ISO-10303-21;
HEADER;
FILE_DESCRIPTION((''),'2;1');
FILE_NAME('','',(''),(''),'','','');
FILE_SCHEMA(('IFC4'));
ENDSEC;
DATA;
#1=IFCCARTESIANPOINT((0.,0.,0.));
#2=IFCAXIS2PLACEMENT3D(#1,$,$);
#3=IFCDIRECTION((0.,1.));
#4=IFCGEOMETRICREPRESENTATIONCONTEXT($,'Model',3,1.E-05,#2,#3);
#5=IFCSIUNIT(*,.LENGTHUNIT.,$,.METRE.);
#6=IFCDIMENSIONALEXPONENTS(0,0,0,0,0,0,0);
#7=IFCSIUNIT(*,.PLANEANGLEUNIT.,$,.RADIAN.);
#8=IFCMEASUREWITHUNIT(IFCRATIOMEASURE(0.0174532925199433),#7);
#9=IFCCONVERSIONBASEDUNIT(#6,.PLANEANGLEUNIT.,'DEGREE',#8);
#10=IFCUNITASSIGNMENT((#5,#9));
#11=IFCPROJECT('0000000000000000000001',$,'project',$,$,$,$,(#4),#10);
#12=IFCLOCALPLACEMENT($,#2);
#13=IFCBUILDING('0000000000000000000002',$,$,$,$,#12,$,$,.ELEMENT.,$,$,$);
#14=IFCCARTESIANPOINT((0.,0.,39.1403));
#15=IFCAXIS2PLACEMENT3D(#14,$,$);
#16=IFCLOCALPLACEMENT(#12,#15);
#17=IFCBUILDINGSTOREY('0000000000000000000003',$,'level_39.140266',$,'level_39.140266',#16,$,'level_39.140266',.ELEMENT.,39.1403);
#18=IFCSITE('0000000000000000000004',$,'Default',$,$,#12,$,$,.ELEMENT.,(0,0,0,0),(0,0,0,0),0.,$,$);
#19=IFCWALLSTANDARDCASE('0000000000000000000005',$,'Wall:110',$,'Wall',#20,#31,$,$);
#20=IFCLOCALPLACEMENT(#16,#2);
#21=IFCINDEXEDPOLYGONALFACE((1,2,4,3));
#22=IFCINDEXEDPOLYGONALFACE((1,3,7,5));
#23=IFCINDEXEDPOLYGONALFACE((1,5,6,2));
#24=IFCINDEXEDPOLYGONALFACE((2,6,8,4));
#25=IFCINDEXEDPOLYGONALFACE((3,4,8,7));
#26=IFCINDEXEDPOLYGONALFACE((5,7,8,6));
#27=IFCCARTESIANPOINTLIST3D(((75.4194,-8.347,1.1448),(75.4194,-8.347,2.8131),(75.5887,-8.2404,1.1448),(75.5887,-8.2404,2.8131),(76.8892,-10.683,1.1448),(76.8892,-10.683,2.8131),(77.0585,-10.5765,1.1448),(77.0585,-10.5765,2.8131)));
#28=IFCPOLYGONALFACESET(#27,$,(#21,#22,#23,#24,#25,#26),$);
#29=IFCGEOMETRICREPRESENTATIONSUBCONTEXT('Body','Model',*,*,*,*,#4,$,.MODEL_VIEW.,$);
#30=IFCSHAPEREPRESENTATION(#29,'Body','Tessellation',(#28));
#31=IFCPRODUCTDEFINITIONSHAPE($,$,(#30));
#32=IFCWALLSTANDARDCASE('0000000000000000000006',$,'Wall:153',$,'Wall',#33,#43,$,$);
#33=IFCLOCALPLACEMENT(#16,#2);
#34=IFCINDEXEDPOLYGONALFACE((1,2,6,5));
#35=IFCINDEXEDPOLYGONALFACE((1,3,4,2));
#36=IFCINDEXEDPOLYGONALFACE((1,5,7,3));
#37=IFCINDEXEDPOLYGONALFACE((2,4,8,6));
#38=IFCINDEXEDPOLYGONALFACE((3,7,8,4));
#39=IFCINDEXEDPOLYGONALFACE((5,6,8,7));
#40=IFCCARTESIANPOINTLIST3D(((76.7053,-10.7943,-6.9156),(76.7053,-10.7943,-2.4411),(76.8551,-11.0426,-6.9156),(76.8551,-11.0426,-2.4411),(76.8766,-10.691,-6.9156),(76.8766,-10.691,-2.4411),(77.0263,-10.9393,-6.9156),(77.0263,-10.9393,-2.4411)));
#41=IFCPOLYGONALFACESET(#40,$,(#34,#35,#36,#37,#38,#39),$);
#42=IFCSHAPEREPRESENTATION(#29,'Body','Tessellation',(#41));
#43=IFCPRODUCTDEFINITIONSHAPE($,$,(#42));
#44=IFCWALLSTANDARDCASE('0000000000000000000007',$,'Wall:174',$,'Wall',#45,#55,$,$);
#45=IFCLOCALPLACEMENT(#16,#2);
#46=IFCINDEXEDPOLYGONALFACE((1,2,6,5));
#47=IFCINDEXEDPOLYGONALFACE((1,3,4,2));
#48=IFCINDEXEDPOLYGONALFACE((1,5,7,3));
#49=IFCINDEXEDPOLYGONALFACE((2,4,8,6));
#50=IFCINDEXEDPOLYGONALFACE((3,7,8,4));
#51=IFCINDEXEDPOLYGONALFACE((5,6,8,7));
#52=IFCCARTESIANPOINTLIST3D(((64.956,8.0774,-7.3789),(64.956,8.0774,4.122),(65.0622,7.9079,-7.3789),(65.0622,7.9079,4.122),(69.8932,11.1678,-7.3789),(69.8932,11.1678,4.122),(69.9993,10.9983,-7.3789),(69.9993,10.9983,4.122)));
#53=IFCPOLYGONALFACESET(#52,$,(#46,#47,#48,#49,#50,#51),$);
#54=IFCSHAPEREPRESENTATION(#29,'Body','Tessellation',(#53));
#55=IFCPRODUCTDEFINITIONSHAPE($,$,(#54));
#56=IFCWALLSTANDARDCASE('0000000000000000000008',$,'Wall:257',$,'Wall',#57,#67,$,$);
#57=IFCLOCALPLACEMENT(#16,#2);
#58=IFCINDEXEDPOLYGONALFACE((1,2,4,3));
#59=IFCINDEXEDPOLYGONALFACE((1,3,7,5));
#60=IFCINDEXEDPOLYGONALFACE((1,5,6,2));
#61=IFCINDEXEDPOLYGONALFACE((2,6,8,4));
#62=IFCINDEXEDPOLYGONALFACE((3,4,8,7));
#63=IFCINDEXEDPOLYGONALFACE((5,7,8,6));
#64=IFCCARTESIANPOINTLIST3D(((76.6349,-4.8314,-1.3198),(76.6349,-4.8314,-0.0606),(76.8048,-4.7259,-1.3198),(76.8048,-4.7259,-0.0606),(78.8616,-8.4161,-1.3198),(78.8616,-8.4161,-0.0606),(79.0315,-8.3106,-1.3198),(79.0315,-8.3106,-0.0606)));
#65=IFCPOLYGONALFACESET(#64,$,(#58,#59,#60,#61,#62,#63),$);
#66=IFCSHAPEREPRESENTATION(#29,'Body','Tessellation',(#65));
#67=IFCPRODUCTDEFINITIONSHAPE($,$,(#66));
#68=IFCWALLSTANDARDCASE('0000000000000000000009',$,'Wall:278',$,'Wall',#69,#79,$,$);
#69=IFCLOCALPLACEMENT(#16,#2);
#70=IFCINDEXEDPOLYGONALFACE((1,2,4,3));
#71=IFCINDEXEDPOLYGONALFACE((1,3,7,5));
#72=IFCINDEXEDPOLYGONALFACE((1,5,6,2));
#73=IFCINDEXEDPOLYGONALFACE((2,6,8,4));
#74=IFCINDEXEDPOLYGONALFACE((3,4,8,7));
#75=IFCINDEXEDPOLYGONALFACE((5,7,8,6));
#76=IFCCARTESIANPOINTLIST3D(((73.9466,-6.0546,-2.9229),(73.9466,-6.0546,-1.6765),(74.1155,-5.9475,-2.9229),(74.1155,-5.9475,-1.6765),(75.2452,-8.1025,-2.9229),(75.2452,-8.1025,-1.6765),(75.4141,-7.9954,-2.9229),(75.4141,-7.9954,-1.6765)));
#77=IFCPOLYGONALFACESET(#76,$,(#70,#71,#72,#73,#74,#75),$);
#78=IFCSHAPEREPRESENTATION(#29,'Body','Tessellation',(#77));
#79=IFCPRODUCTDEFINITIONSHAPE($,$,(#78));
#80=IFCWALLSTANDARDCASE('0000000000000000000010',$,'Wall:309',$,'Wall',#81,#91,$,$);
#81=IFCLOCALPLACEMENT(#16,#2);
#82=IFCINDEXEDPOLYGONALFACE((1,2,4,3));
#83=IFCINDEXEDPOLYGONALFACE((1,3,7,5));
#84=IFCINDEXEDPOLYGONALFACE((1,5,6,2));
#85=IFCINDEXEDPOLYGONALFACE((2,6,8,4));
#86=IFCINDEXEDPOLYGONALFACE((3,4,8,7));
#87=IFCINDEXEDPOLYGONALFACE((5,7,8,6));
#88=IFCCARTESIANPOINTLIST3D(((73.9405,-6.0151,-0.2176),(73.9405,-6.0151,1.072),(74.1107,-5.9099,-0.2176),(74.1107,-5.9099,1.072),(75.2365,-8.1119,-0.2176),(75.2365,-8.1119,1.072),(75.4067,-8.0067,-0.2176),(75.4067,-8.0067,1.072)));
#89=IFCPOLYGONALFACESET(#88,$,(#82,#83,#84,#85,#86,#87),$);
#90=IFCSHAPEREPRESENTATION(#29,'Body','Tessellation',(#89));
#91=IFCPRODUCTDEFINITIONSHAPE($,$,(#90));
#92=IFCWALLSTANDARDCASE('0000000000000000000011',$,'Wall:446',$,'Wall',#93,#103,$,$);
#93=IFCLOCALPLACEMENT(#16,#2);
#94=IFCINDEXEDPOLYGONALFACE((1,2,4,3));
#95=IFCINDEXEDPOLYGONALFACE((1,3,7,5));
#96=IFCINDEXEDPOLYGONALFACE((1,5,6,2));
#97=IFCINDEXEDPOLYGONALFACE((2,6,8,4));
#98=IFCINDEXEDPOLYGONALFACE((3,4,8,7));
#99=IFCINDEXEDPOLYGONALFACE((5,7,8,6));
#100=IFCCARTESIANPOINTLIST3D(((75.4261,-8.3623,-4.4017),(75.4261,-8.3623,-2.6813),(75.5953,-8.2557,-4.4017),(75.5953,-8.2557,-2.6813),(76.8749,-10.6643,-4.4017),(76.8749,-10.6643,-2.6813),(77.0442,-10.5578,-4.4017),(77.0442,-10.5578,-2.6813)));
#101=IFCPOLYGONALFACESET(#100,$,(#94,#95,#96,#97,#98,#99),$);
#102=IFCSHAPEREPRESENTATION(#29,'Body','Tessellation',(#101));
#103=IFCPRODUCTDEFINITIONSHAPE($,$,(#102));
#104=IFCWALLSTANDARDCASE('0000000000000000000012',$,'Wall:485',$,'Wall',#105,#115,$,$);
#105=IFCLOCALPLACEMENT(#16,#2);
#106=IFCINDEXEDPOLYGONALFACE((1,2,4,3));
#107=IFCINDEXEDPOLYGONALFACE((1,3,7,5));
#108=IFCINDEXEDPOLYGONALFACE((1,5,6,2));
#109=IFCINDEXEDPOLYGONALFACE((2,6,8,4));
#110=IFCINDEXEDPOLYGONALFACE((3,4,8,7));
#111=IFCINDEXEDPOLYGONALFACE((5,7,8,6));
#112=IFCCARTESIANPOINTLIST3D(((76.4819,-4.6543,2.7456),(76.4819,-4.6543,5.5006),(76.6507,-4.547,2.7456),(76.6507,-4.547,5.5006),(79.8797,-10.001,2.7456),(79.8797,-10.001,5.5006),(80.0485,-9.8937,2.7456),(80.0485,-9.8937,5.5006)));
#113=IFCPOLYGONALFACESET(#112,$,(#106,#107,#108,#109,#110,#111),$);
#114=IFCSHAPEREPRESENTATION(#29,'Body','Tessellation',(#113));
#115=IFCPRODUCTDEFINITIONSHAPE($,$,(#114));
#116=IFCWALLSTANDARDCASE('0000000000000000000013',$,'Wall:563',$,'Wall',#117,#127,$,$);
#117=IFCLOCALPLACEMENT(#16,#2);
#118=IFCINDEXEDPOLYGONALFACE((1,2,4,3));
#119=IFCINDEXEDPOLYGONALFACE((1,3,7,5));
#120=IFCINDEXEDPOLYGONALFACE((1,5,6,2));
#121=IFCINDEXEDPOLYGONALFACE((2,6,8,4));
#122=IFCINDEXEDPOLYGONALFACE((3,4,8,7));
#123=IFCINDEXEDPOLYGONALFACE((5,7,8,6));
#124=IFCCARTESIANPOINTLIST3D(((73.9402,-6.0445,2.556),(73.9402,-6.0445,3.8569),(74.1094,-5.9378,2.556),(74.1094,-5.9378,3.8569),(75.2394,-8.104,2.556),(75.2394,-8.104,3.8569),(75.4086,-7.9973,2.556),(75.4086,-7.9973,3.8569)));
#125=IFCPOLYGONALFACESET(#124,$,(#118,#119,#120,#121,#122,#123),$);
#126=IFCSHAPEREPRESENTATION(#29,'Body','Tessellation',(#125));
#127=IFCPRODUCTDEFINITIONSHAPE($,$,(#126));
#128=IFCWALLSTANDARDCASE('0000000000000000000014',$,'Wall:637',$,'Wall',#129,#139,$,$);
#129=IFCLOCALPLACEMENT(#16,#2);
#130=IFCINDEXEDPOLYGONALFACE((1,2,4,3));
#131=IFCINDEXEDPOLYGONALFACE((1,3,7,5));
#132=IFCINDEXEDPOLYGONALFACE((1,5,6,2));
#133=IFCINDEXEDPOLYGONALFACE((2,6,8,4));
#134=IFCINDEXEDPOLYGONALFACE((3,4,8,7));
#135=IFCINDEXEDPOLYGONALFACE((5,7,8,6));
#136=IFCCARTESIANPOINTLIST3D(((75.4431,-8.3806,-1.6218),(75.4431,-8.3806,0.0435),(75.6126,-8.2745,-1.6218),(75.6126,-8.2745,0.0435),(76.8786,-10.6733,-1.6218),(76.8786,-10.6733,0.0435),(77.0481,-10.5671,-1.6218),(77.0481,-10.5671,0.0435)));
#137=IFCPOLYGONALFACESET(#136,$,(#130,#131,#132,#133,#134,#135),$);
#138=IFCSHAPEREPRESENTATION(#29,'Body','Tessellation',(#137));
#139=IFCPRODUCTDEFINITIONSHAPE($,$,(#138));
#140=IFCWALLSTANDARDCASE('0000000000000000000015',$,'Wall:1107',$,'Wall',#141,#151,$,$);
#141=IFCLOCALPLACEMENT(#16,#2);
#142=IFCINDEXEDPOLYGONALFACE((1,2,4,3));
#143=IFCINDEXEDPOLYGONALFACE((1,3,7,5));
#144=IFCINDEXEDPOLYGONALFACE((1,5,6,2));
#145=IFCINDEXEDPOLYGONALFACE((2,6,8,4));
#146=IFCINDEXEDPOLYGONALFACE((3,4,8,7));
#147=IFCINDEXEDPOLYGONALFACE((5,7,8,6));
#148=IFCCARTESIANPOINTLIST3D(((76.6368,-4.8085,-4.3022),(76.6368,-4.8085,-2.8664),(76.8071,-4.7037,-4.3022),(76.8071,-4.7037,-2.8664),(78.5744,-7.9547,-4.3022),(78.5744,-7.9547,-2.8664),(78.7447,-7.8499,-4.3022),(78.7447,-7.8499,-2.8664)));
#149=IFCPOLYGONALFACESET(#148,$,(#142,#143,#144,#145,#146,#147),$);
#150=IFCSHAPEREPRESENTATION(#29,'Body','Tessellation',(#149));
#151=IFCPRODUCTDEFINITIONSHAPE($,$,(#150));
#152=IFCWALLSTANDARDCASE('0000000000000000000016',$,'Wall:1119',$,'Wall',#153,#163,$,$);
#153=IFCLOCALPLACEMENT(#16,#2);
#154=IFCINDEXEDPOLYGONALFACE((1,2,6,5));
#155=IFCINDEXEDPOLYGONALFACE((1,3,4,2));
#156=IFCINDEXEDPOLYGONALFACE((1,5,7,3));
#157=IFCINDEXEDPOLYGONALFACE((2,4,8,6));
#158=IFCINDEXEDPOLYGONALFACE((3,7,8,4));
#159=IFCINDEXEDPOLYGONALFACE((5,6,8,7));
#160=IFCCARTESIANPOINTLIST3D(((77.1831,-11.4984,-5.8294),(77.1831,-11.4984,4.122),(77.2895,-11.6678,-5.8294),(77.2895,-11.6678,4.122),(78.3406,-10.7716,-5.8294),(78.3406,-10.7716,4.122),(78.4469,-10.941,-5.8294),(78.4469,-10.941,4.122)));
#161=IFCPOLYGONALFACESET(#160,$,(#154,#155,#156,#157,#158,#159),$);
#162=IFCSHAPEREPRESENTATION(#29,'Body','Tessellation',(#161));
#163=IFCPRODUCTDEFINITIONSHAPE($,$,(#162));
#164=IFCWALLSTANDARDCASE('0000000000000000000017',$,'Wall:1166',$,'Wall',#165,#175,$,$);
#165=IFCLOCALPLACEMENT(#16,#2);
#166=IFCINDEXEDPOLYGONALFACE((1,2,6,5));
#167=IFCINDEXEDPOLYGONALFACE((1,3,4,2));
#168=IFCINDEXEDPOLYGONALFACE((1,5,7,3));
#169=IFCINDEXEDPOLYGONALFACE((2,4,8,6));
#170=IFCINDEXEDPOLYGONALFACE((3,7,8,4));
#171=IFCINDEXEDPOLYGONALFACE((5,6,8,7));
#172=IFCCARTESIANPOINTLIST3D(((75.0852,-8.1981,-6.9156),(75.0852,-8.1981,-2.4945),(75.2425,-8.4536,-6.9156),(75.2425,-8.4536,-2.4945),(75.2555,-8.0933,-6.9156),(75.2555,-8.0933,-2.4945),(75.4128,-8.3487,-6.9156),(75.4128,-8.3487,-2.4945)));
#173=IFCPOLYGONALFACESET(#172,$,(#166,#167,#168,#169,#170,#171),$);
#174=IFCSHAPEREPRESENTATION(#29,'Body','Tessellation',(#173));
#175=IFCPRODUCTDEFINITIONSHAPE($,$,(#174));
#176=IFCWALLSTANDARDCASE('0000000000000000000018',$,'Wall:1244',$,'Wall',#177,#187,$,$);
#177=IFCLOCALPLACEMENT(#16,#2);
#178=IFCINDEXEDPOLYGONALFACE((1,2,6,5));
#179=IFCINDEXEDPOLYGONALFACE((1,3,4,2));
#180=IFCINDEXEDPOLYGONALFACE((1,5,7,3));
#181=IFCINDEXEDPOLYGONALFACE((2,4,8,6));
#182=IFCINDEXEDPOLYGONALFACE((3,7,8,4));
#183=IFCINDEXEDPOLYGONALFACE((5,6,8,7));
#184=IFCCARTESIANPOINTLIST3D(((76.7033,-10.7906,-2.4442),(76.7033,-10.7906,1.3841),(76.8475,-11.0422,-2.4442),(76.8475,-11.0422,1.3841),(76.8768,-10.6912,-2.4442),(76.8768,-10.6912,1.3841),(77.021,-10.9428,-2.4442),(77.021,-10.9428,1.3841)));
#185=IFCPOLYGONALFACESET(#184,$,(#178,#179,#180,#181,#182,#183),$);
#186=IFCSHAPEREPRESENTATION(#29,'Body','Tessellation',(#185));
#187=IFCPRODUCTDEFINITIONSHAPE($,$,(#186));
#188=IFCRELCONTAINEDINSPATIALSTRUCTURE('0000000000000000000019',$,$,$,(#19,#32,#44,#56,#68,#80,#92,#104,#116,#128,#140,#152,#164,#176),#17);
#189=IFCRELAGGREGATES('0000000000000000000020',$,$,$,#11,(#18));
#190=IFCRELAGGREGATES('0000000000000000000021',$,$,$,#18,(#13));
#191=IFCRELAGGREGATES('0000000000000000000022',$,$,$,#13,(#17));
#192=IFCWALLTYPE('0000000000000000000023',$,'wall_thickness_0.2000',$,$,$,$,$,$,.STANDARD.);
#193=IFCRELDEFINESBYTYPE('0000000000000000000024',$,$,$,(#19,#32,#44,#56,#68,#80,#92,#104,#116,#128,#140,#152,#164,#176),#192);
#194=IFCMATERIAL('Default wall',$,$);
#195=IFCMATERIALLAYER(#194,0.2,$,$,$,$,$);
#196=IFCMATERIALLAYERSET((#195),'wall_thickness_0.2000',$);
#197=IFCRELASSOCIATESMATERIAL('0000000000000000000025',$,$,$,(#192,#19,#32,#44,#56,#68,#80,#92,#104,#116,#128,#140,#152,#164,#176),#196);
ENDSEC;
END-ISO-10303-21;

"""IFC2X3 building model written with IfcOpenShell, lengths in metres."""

from ifc_helpers import new_model, entity, si_unit, converted_unit, direction, frame, origin, place, context, subcontext, project, spatial, polyline, outline, extrude, material, layer, layer_set, layer_usage, type_object, element, save


model = new_model("IFC2X3")

# Units and contexts
model_context = context("Model", 3, precision=1e-05, world=origin(), true_north=direction((0.0, 1.0)))
body_context = subcontext(model_context, "Body", "Model", "MODEL_VIEW")
ifc_project = project(units=[si_unit("LENGTHUNIT", "METRE"), converted_unit("PLANEANGLEUNIT", "DEGREE", entity("IfcRatioMeasure", 0.0174532925199433), si_unit("PLANEANGLEUNIT", "RADIAN"), dimensions=[0, 0, 0, 0, 0, 0, 0])], contexts=[model_context])

# Site, building, storey
placement_1 = place(None, origin())
site = spatial("IfcSite", under=ifc_project, at=placement_1, Name="Default", CompositionType="ELEMENT", RefLatitude=(0, 0, 0, 0), RefLongitude=(0, 0, 0, 0), RefElevation=0.0)
building = spatial("IfcBuilding", under=site, at=placement_1, CompositionType="ELEMENT")
storey_placement = place(placement_1, frame((0.0, 0.0, 39.1403)))
storey = spatial("IfcBuildingStorey", under=building, at=storey_placement, Name="level_39.140266", ObjectType="level_39.140266", LongName="level_39.140266", CompositionType="ELEMENT", Elevation=39.1403)

# Walls
ifc_material = material(Name="Default wall")
ifc_layer = layer(ifc_material, 0.2)
ifc_layer_set = layer_set([ifc_layer], Name="wall_thickness_0.2000")
ifc_layer_usage = layer_usage(ifc_layer_set, "AXIS2", "POSITIVE", -0.1)
wall_type = type_object("IfcWallType", Name="wall_thickness_0.2000", PredefinedType="STANDARD", material=ifc_layer_set)
placement_2 = place(placement_1, frame((0.0, 0.0, 40.2851)))
wall_1_placement = place(placement_2, frame((75.504, -8.2937, 0.0), z_axis=(0.0, 0.0, 1.0), x_axis=(0.532531, -0.84641, 0.0)))
element("IfcWallStandardCase", 1, at=wall_1_placement, inside=storey, type_object=wall_type, material=ifc_layer_usage, Name="Wall:110", ObjectType="Wall", context=body_context, shape_type="SweptSolid", body=[
    extrude(outline(polyline([(2.76, -0.1), (2.76, 0.1), (0.0, 0.1), (0.0, -0.1), (2.76, -0.1)])), origin(), (0.0, 0.0, 1.0), 1.6683),
])
placement_3 = place(placement_1, frame((0.0, 0.0, 32.2247)))
wall_2_placement = place(placement_3, frame((76.7909, -10.7427, 0.0), z_axis=(0.0, 0.0, 1.0), x_axis=(0.516457, -0.856313, 0.0)))
element("IfcWallStandardCase", 2, at=wall_2_placement, inside=storey, type_object=wall_type, material=ifc_layer_usage, Name="Wall:153", ObjectType="Wall", context=body_context, shape_type="SweptSolid", body=[
    extrude(outline(polyline([(0.29, -0.1), (0.29, 0.1), (0.0, 0.1), (0.0, -0.1), (0.29, -0.1)])), origin(), (0.0, 0.0, 1.0), 4.4746),
])
placement_4 = place(placement_1, frame((0.0, 0.0, 31.7614)))
wall_3_placement = place(placement_4, frame((69.9462, 11.083, 0.0), z_axis=(0.0, 0.0, 1.0), x_axis=(-0.847635, -0.530581, 0.0)))
element("IfcWallStandardCase", 3, at=wall_3_placement, inside=storey, type_object=wall_type, material=ifc_layer_usage, Name="Wall:174", ObjectType="Wall", context=body_context, shape_type="SweptSolid", body=[
    extrude(outline(polyline([(5.8246, -0.1), (5.8246, 0.1), (0.0, 0.1), (0.0, -0.1), (5.8246, -0.1)])), origin(), (0.0, 0.0, 1.0), 11.5009),
])
placement_5 = place(placement_1, frame((0.0, 0.0, 37.8205)))
wall_4_placement = place(placement_5, frame((76.7198, -4.7787, 0.0), z_axis=(0.0, 0.0, 1.0), x_axis=(0.527667, -0.849452, 0.0)))
element("IfcWallStandardCase", 4, at=wall_4_placement, inside=storey, type_object=wall_type, material=ifc_layer_usage, Name="Wall:257", ObjectType="Wall", context=body_context, shape_type="SweptSolid", body=[
    extrude(outline(polyline([(4.22, -0.1), (4.22, 0.1), (0.0, 0.1), (0.0, -0.1), (4.22, -0.1)])), origin(), (0.0, 0.0, 1.0), 1.2592),
])
placement_6 = place(placement_1, frame((0.0, 0.0, 36.2174)))
wall_5_placement = place(placement_6, frame((74.031, -6.001, 0.0), z_axis=(0.0, 0.0, 1.0), x_axis=(0.535521, -0.844522, 0.0)))
element("IfcWallStandardCase", 5, at=wall_5_placement, inside=storey, type_object=wall_type, material=ifc_layer_usage, Name="Wall:278", ObjectType="Wall", context=body_context, shape_type="SweptSolid", body=[
    extrude(outline(polyline([(2.425, -0.1), (2.425, 0.1), (0.0, 0.1), (0.0, -0.1), (2.425, -0.1)])), origin(), (0.0, 0.0, 1.0), 1.2464),
])
placement_7 = place(placement_1, frame((0.0, 0.0, 38.9227)))
wall_6_placement = place(placement_7, frame((74.0256, -5.9625, 0.0), z_axis=(0.0, 0.0, 1.0), x_axis=(0.52576, -0.850633, 0.0)))
element("IfcWallStandardCase", 6, at=wall_6_placement, inside=storey, type_object=wall_type, material=ifc_layer_usage, Name="Wall:309", ObjectType="Wall", context=body_context, shape_type="SweptSolid", body=[
    extrude(outline(polyline([(2.465, -0.1), (2.465, 0.1), (0.0, 0.1), (0.0, -0.1), (2.465, -0.1)])), origin(), (0.0, 0.0, 1.0), 1.2896),
])
placement_8 = place(placement_1, frame((0.0, 0.0, 34.7386)))
wall_7_placement = place(placement_8, frame((75.5107, -8.309, 0.0), z_axis=(0.0, 0.0, 1.0), x_axis=(0.532652, -0.846334, 0.0)))
element("IfcWallStandardCase", 7, at=wall_7_placement, inside=storey, type_object=wall_type, material=ifc_layer_usage, Name="Wall:446", ObjectType="Wall", context=body_context, shape_type="SweptSolid", body=[
    extrude(outline(polyline([(2.72, -0.1), (2.72, 0.1), (0.0, 0.1), (0.0, -0.1), (2.72, -0.1)])), origin(), (0.0, 0.0, 1.0), 1.7205),
])
placement_9 = place(placement_1, frame((0.0, 0.0, 41.8859)))
wall_8_placement = place(placement_9, frame((76.5663, -4.6006, 0.0), z_axis=(0.0, 0.0, 1.0), x_axis=(0.536352, -0.843994, 0.0)))
element("IfcWallStandardCase", 8, at=wall_8_placement, inside=storey, type_object=wall_type, material=ifc_layer_usage, Name="Wall:485", ObjectType="Wall", context=body_context, shape_type="SweptSolid", body=[
    extrude(outline(polyline([(6.335, -0.1), (6.335, 0.1), (0.0, 0.1), (0.0, -0.1), (6.335, -0.1)])), origin(), (0.0, 0.0, 1.0), 2.755),
])
placement_10 = place(placement_1, frame((0.0, 0.0, 41.6963)))
wall_9_placement = place(placement_10, frame((74.0248, -5.9912, 0.0), z_axis=(0.0, 0.0, 1.0), x_axis=(0.533566, -0.845759, 0.0)))
element("IfcWallStandardCase", 9, at=wall_9_placement, inside=storey, type_object=wall_type, material=ifc_layer_usage, Name="Wall:563", ObjectType="Wall", context=body_context, shape_type="SweptSolid", body=[
    extrude(outline(polyline([(2.435, -0.1), (2.435, 0.1), (0.0, 0.1), (0.0, -0.1), (2.435, -0.1)])), origin(), (0.0, 0.0, 1.0), 1.3009),
])
placement_11 = place(placement_1, frame((0.0, 0.0, 37.5185)))
wall_10_placement = place(placement_11, frame((75.5279, -8.3276, 0.0), z_axis=(0.0, 0.0, 1.0), x_axis=(0.530693, -0.847564, 0.0)))
element("IfcWallStandardCase", 10, at=wall_10_placement, inside=storey, type_object=wall_type, material=ifc_layer_usage, Name="Wall:637", ObjectType="Wall", context=body_context, shape_type="SweptSolid", body=[
    extrude(outline(polyline([(2.705, -0.1), (2.705, 0.1), (0.0, 0.1), (0.0, -0.1), (2.705, -0.1)])), origin(), (0.0, 0.0, 1.0), 1.6653),
])
placement_12 = place(placement_1, frame((0.0, 0.0, 34.8381)))
wall_11_placement = place(placement_12, frame((76.722, -4.7561, 0.0), z_axis=(0.0, 0.0, 1.0), x_axis=(0.524388, -0.851479, 0.0)))
element("IfcWallStandardCase", 11, at=wall_11_placement, inside=storey, type_object=wall_type, material=ifc_layer_usage, Name="Wall:1107", ObjectType="Wall", context=body_context, shape_type="SweptSolid", body=[
    extrude(outline(polyline([(3.695, -0.1), (3.695, 0.1), (0.0, 0.1), (0.0, -0.1), (3.695, -0.1)])), origin(), (0.0, 0.0, 1.0), 1.4359),
])
placement_13 = place(placement_1, frame((0.0, 0.0, 33.3109)))
wall_12_placement = place(placement_13, frame((77.2363, -11.5831, 0.0), z_axis=(0.0, 0.0, 1.0), x_axis=(0.846893, 0.531764, 0.0)))
element("IfcWallStandardCase", 12, at=wall_12_placement, inside=storey, type_object=wall_type, material=ifc_layer_usage, Name="Wall:1119", ObjectType="Wall", context=body_context, shape_type="SweptSolid", body=[
    extrude(outline(polyline([(1.3668, -0.1), (1.3668, 0.1), (0.0, 0.1), (0.0, -0.1), (1.3668, -0.1)])), origin(), (0.0, 0.0, 1.0), 9.9514),
])
placement_14 = place(placement_1, frame((0.0, 0.0, 32.2247)))
wall_13_placement = place(placement_14, frame((75.3277, -8.4011, 0.0), z_axis=(0.0, 0.0, 1.0), x_axis=(-0.524422, 0.851458, 0.0)))
element("IfcWallStandardCase", 13, at=wall_13_placement, inside=storey, type_object=wall_type, material=ifc_layer_usage, Name="Wall:1166", ObjectType="Wall", context=body_context, shape_type="SweptSolid", body=[
    extrude(outline(polyline([(0.3, -0.1), (0.3, 0.1), (0.0, 0.1), (0.0, -0.1), (0.3, -0.1)])), origin(), (0.0, 0.0, 1.0), 4.4212),
])
placement_15 = place(placement_1, frame((0.0, 0.0, 36.6961)))
wall_14_placement = place(placement_15, frame((76.9342, -10.9925, 0.0), z_axis=(0.0, 0.0, 1.0), x_axis=(-0.497255, 0.867605, 0.0)))
element("IfcWallStandardCase", 14, at=wall_14_placement, inside=storey, type_object=wall_type, material=ifc_layer_usage, Name="Wall:1244", ObjectType="Wall", context=body_context, shape_type="SweptSolid", body=[
    extrude(outline(polyline([(0.29, -0.1), (0.29, 0.1), (0.0, 0.1), (0.0, -0.1), (0.29, -0.1)])), origin(), (0.0, 0.0, 1.0), 3.8284),
])

save(model, "model.ifc")
